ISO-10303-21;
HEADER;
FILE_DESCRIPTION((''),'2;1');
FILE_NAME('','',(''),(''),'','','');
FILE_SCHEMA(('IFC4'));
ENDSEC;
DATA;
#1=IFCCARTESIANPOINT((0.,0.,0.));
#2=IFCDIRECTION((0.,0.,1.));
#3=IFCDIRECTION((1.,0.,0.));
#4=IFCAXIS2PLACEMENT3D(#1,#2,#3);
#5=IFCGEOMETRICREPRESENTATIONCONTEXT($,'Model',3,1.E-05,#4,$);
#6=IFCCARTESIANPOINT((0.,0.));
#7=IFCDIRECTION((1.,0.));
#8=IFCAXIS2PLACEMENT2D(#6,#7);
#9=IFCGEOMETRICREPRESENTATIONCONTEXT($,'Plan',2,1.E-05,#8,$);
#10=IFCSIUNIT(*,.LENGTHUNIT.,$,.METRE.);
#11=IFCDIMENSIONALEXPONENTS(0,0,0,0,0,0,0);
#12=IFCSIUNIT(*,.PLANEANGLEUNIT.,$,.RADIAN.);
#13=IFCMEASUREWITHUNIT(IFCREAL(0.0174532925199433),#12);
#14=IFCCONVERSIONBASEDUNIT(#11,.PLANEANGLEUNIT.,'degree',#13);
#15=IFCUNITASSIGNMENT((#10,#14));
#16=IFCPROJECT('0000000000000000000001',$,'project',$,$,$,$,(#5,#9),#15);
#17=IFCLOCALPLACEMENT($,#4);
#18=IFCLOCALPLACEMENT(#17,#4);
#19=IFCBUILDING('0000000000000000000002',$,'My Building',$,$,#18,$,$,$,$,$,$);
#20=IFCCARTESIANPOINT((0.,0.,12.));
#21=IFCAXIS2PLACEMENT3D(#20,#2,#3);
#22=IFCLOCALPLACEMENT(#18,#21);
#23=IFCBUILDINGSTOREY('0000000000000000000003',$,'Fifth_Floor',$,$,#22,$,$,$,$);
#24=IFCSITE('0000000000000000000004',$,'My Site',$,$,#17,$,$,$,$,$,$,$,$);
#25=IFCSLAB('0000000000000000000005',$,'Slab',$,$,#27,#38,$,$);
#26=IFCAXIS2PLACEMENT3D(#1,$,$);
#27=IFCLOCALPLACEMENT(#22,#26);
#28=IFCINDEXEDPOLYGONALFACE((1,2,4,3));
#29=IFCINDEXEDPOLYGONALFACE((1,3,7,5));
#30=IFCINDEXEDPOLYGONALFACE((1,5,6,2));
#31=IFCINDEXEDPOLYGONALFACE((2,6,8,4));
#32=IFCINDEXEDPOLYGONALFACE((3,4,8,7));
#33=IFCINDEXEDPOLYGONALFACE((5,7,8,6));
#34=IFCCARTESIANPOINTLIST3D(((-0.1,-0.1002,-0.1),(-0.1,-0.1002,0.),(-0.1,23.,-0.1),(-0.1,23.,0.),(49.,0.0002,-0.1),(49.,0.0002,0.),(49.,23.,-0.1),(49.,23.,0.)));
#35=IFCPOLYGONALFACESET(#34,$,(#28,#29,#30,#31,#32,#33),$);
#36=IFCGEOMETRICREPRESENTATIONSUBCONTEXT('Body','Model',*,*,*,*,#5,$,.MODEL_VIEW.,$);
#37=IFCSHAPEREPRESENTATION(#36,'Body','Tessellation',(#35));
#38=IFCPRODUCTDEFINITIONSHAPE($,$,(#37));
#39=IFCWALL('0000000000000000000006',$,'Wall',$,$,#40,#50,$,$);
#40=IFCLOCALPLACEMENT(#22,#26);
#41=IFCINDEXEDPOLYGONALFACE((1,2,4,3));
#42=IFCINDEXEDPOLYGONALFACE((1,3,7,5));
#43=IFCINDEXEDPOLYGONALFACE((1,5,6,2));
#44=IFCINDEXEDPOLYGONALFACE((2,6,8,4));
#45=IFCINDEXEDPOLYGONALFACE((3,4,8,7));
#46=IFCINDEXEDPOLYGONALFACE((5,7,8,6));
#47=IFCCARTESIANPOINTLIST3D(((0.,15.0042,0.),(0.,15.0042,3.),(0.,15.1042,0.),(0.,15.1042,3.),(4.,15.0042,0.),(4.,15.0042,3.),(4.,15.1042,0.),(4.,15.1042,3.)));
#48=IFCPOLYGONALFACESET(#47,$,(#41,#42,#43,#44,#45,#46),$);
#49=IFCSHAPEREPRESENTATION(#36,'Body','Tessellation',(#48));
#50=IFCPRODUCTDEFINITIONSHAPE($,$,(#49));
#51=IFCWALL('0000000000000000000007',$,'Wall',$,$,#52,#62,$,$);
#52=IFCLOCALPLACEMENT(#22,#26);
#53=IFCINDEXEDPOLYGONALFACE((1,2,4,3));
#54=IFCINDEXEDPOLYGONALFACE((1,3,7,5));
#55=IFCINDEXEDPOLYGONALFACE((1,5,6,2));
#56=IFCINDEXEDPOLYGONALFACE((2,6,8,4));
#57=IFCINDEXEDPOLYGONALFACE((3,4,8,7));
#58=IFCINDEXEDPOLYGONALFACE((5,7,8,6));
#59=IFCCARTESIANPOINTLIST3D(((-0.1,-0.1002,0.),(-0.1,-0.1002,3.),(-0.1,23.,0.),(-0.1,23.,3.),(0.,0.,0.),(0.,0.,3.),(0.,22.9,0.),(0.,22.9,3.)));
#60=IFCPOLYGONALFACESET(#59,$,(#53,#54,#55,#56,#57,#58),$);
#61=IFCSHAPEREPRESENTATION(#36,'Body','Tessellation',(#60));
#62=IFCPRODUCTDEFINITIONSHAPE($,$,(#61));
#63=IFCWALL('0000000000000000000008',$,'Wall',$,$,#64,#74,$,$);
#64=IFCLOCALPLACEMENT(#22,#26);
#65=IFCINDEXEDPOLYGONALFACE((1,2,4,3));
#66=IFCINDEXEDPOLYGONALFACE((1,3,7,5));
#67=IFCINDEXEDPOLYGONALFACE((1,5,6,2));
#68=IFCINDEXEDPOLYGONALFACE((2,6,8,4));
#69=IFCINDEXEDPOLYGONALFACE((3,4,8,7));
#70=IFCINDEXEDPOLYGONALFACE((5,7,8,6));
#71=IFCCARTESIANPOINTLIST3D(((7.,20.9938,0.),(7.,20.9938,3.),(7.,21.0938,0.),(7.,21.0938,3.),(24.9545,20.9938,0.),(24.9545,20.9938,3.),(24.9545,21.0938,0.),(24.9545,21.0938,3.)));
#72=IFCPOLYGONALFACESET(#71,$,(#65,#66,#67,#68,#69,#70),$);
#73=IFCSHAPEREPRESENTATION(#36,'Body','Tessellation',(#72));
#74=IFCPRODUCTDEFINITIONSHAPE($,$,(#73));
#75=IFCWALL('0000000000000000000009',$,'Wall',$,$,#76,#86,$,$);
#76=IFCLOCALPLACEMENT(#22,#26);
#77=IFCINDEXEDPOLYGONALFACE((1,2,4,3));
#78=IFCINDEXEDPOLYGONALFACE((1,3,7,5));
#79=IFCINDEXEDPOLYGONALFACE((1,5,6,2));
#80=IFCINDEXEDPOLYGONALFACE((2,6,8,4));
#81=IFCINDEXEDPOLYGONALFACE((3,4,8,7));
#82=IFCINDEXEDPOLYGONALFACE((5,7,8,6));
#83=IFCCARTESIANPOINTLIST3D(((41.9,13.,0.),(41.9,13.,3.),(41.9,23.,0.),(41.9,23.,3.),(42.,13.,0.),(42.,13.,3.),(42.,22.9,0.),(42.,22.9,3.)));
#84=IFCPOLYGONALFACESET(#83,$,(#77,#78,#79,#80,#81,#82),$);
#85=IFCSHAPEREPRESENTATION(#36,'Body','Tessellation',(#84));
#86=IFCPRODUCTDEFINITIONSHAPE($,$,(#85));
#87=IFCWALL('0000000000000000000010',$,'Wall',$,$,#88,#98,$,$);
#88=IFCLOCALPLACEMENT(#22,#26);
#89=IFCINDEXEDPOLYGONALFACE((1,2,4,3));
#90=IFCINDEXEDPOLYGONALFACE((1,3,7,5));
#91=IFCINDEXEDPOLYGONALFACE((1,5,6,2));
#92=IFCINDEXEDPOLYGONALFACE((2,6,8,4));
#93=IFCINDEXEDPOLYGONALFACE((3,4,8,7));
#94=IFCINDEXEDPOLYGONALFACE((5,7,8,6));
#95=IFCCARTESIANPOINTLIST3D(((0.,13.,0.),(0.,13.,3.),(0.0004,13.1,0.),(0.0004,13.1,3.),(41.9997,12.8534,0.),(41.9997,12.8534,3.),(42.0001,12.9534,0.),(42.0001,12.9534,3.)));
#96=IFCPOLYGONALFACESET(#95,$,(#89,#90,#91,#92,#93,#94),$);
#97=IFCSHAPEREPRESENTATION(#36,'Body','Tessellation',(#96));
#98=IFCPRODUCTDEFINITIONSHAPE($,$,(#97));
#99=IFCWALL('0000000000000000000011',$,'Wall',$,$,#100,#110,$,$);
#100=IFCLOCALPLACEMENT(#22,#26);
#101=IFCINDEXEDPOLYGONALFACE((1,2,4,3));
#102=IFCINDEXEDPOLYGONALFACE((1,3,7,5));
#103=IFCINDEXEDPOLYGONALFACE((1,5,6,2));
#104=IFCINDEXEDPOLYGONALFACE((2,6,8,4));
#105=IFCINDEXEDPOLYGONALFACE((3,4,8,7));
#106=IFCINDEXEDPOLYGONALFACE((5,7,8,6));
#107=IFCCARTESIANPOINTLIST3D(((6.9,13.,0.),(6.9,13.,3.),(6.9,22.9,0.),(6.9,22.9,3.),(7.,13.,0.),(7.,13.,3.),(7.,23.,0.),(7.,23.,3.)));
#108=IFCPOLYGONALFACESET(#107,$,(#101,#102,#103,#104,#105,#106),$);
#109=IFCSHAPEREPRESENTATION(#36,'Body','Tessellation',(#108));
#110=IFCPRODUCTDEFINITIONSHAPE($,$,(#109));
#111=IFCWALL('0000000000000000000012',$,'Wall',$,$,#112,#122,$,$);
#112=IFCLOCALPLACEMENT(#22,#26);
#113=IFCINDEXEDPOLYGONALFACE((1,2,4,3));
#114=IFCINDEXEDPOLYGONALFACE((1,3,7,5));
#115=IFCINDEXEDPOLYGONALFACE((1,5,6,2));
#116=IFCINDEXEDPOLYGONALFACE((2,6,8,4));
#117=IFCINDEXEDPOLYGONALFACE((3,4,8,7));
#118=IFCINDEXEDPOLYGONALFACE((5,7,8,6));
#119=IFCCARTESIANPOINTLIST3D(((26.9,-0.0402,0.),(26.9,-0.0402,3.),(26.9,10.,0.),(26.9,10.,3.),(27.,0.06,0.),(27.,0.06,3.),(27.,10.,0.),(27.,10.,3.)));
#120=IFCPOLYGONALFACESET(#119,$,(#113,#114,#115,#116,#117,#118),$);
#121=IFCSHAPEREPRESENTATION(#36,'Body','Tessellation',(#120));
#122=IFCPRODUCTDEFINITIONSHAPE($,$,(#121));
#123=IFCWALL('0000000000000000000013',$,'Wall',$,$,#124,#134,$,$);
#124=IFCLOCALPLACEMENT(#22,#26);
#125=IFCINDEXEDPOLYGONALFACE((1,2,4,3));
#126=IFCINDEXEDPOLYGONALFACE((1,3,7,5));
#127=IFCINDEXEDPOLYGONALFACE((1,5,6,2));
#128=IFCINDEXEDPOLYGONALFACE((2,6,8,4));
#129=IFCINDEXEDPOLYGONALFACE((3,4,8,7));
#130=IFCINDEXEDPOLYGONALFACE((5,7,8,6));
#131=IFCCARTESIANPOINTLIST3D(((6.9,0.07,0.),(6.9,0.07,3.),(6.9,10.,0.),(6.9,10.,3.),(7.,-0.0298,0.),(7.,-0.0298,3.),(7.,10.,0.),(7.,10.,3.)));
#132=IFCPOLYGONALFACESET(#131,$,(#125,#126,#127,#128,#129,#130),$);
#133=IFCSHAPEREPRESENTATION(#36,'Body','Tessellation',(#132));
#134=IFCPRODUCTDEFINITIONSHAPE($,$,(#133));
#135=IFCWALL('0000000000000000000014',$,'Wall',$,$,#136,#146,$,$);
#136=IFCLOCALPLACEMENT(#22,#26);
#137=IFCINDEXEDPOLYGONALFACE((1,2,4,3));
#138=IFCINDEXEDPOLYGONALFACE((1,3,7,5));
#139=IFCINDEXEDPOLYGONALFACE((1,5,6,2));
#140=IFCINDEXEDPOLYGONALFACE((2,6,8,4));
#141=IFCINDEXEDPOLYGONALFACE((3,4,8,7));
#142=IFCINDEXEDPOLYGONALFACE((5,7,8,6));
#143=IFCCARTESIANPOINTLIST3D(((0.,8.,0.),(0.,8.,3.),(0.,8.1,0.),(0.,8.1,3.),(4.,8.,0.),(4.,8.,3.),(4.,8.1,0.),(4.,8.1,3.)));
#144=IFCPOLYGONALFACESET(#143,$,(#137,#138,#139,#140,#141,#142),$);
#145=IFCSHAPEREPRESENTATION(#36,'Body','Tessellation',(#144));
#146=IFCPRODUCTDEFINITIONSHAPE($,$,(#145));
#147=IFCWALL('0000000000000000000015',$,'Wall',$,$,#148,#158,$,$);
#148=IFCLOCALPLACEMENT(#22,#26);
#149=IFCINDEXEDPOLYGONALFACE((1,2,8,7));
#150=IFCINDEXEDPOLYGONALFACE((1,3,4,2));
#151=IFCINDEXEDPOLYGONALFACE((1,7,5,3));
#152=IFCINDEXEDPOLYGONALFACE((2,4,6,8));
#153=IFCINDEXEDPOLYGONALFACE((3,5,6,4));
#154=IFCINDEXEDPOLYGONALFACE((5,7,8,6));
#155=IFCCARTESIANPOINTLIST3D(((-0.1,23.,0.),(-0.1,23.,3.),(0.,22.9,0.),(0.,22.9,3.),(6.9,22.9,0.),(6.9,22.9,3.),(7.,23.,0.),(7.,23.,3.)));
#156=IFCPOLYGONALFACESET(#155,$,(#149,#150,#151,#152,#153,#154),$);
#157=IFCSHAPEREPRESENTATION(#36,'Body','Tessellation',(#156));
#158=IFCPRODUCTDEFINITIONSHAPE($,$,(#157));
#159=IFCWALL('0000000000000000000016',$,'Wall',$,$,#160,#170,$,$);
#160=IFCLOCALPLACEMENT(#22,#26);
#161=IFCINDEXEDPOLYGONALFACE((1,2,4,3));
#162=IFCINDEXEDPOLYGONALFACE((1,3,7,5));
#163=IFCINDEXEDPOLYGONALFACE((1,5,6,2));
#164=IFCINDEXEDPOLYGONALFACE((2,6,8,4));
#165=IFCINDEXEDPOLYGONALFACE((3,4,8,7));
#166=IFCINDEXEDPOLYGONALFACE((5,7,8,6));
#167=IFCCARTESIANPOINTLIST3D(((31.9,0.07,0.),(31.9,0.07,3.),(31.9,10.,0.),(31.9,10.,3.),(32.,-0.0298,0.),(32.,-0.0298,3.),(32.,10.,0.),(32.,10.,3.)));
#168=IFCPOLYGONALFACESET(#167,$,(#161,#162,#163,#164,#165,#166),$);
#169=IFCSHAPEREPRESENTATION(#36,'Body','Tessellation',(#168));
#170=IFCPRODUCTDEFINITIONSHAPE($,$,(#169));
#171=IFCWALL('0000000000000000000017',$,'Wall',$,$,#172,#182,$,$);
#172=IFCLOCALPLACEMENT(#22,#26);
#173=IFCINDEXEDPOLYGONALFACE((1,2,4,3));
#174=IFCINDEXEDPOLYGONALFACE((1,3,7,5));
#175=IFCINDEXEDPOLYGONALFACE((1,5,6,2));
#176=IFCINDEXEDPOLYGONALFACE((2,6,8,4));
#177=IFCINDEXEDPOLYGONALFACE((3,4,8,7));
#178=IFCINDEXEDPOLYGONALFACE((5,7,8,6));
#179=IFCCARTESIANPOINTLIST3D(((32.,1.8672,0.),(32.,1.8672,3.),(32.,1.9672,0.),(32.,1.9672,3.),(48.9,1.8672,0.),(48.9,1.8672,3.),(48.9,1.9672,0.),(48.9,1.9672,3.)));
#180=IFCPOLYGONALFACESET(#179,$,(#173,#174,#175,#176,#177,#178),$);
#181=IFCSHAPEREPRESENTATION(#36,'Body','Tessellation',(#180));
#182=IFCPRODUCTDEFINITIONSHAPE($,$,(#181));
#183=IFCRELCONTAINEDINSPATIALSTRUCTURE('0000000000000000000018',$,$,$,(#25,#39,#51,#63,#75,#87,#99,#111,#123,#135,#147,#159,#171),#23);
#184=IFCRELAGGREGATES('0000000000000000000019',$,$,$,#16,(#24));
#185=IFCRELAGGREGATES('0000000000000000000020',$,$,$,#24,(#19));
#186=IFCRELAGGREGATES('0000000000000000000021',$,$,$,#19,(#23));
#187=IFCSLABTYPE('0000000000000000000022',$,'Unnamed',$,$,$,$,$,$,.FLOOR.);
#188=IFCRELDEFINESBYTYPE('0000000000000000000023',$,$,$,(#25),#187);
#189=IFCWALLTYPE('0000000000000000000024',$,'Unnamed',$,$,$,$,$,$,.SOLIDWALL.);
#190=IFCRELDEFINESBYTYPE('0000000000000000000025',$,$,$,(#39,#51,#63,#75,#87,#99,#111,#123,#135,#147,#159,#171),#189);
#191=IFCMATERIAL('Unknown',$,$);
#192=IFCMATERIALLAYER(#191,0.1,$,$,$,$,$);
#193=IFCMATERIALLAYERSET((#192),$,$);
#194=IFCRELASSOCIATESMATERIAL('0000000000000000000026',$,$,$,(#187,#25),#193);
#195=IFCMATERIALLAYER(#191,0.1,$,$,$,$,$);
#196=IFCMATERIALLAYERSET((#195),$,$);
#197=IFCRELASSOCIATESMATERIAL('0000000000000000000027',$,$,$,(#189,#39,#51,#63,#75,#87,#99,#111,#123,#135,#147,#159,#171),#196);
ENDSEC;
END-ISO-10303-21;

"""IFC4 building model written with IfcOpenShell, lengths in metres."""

from ifc_helpers import new_model, entity, si_unit, converted_unit, frame, origin_with_axes, origin_2d_with_axis, place, context, subcontext, project, spatial, line, indexed_curve, outline, extrude, material, layer, layer_set, layer_usage, type_object, element, save


model = new_model("IFC4")

# Units and contexts
model_context = context("Model", 3, precision=1e-05, world=origin_with_axes())
plan_context = context("Plan", 2, precision=1e-05, world=origin_2d_with_axis())
body_context = subcontext(model_context, "Body", "Model", "MODEL_VIEW")
ifc_project = project(units=[si_unit("LENGTHUNIT", "METRE"), converted_unit("PLANEANGLEUNIT", "degree", entity("IfcReal", 0.0174532925199433), si_unit("PLANEANGLEUNIT", "RADIAN"), dimensions=[0, 0, 0, 0, 0, 0, 0])], contexts=[model_context, plan_context])

# Site, building, storey
site_placement = place(None, origin_with_axes())
site = spatial("IfcSite", under=ifc_project, at=site_placement, Name="My Site")
building_placement = place(site_placement, origin_with_axes())
building = spatial("IfcBuilding", under=site, at=building_placement, Name="My Building")
storey_placement = place(building_placement, frame((0.0, 0.0, 12.0), z_axis=(0.0, 0.0, 1.0), x_axis=(1.0, 0.0, 0.0)))
storey = spatial("IfcBuildingStorey", under=building, at=storey_placement, Name="Fifth_Floor")

# Slab
ifc_material = material(Name="Unknown")
ifc_layer_1 = layer(ifc_material, 0.1)
ifc_layer_set_1 = layer_set([ifc_layer_1])
ifc_layer_usage_1 = layer_usage(ifc_layer_set_1, "AXIS3", "POSITIVE", -0.1)
slab_type = type_object("IfcSlabType", Name="Unnamed", PredefinedType="FLOOR", material=ifc_layer_set_1)
slab_placement = place(storey_placement, frame((-0.1, 23.0, 0.0), z_axis=(0.0, 0.0, 1.0), x_axis=(1.0, 0.0, 0.0)))
element("IfcSlab", 1, at=slab_placement, inside=storey, type_object=slab_type, material=ifc_layer_usage_1, Name="Slab", context=body_context, shape_type="SweptSolid", body=[
    extrude(outline(indexed_curve([(0.0, -23.1002), (49.1, -22.9998), (49.1, 0.0), (0.0, 0.0), (0.0, -23.1002)])), frame((0.0, 0.0, -0.1), z_axis=(0.0, 0.0, 1.0), x_axis=(1.0, 0.0, 0.0)), (0.0, 0.0, 1.0), 0.1),
])

# Walls
ifc_layer_2 = layer(ifc_material, 0.1)
ifc_layer_set_2 = layer_set([ifc_layer_2])
ifc_layer_usage_2 = layer_usage(ifc_layer_set_2, "AXIS2", "POSITIVE", 0.0)
wall_type = type_object("IfcWallType", Name="Unnamed", PredefinedType="SOLIDWALL", material=ifc_layer_set_2)
wall_1_placement = place(storey_placement, frame((0.0, 15.0042, 0.0), z_axis=(0.0, 0.0, 1.0), x_axis=(1.0, 0.0, 0.0)))
element("IfcWall", 2, at=wall_1_placement, inside=storey, type_object=wall_type, material=ifc_layer_usage_2, Name="Wall", context=body_context, shape_type="SweptSolid", body=[
    extrude(outline(indexed_curve([(0.0, 0.0), (0.0, 0.1), (4.0, 0.1), (4.0, 0.0)], segments=[line(1, 2, 3, 4, 1)])), origin_with_axes(), (0.0, 0.0, 1.0), 3.0),
])
ifc_layer_usage_3 = layer_usage(ifc_layer_set_2, "AXIS2", "POSITIVE", 0.0)
wall_2_placement = place(storey_placement, frame((0.0, 0.0, 0.0), z_axis=(0.0, 0.0, 1.0), x_axis=(0.0, 1.0, 0.0)))
element("IfcWall", 3, at=wall_2_placement, inside=storey, type_object=wall_type, material=ifc_layer_usage_3, Name="Wall", context=body_context, shape_type="SweptSolid", body=[
    extrude(outline(indexed_curve([(0.0, 0.0), (-0.1002, 0.1), (23.0, 0.1), (22.9, 0.0)], segments=[line(1, 2, 3, 4, 1)])), origin_with_axes(), (0.0, 0.0, 1.0), 3.0),
])
ifc_layer_usage_4 = layer_usage(ifc_layer_set_2, "AXIS2", "POSITIVE", 0.0)
wall_3_placement = place(storey_placement, frame((7.0, 20.9938, 0.0), z_axis=(0.0, 0.0, 1.0), x_axis=(1.0, 0.0, 0.0)))
element("IfcWall", 4, at=wall_3_placement, inside=storey, type_object=wall_type, material=ifc_layer_usage_4, Name="Wall", context=body_context, shape_type="SweptSolid", body=[
    extrude(outline(indexed_curve([(0.0, 0.0), (0.0, 0.1), (17.9545, 0.1), (17.9545, 0.0)], segments=[line(1, 2, 3, 4, 1)])), origin_with_axes(), (0.0, 0.0, 1.0), 3.0),
])
ifc_layer_usage_5 = layer_usage(ifc_layer_set_2, "AXIS2", "POSITIVE", 0.0)
wall_4_placement = place(storey_placement, frame((41.9, 22.9, 0.0), z_axis=(0.0, 0.0, 1.0), x_axis=(0.0, -1.0, 0.0)))
element("IfcWall", 5, at=wall_4_placement, inside=storey, type_object=wall_type, material=ifc_layer_usage_5, Name="Wall", context=body_context, shape_type="SweptSolid", body=[
    extrude(outline(indexed_curve([(-0.1, 0.0), (0.0, 0.1), (9.9, 0.1), (9.9, 0.0)], segments=[line(1, 2, 3, 4, 1)])), origin_with_axes(), (0.0, 0.0, 1.0), 3.0),
])
ifc_layer_usage_6 = layer_usage(ifc_layer_set_2, "AXIS2", "POSITIVE", 0.0)
wall_5_placement = place(storey_placement, frame((0.0, 13.0, 0.0), z_axis=(0.0, 0.0, 1.0), x_axis=(0.999994, -0.003491, 0.0)))
element("IfcWall", 6, at=wall_5_placement, inside=storey, type_object=wall_type, material=ifc_layer_usage_6, Name="Wall", context=body_context, shape_type="SweptSolid", body=[
    extrude(outline(indexed_curve([(0.0, 0.0), (0.0, 0.1), (42.0, 0.1), (42.0, 0.0)], segments=[line(1, 2, 3, 4, 1)])), origin_with_axes(), (0.0, 0.0, 1.0), 3.0),
])
ifc_layer_usage_7 = layer_usage(ifc_layer_set_2, "AXIS2", "POSITIVE", 0.0)
wall_6_placement = place(storey_placement, frame((6.9, 22.9, 0.0), z_axis=(0.0, 0.0, 1.0), x_axis=(0.0, -1.0, 0.0)))
element("IfcWall", 7, at=wall_6_placement, inside=storey, type_object=wall_type, material=ifc_layer_usage_7, Name="Wall", context=body_context, shape_type="SweptSolid", body=[
    extrude(outline(indexed_curve([(0.0, 0.0), (-0.1, 0.1), (9.9, 0.1), (9.9, 0.0)], segments=[line(1, 2, 3, 4, 1)])), origin_with_axes(), (0.0, 0.0, 1.0), 3.0),
])
ifc_layer_usage_8 = layer_usage(ifc_layer_set_2, "AXIS2", "POSITIVE", 0.0)
wall_7_placement = place(storey_placement, frame((26.9, 10.0, 0.0), z_axis=(0.0, 0.0, 1.0), x_axis=(0.0, -1.0, 0.0)))
element("IfcWall", 8, at=wall_7_placement, inside=storey, type_object=wall_type, material=ifc_layer_usage_8, Name="Wall", context=body_context, shape_type="SweptSolid", body=[
    extrude(outline(indexed_curve([(0.0, 0.0), (0.0, 0.1), (9.94, 0.1), (10.0402, 0.0)], segments=[line(1, 2, 3, 4, 1)])), origin_with_axes(), (0.0, 0.0, 1.0), 3.0),
])
ifc_layer_usage_9 = layer_usage(ifc_layer_set_2, "AXIS2", "POSITIVE", 0.0)
wall_8_placement = place(storey_placement, frame((6.9, 10.0, 0.0), z_axis=(0.0, 0.0, 1.0), x_axis=(0.0, -1.0, 0.0)))
element("IfcWall", 9, at=wall_8_placement, inside=storey, type_object=wall_type, material=ifc_layer_usage_9, Name="Wall", context=body_context, shape_type="SweptSolid", body=[
    extrude(outline(indexed_curve([(0.0, 0.0), (0.0, 0.1), (10.0298, 0.1), (9.93, 0.0)], segments=[line(1, 2, 3, 4, 1)])), origin_with_axes(), (0.0, 0.0, 1.0), 3.0),
])
ifc_layer_usage_10 = layer_usage(ifc_layer_set_2, "AXIS2", "POSITIVE", 0.0)
wall_9_placement = place(storey_placement, frame((0.0, 8.0, 0.0), z_axis=(0.0, 0.0, 1.0), x_axis=(1.0, 0.0, 0.0)))
element("IfcWall", 10, at=wall_9_placement, inside=storey, type_object=wall_type, material=ifc_layer_usage_10, Name="Wall", context=body_context, shape_type="SweptSolid", body=[
    extrude(outline(indexed_curve([(0.0, 0.0), (0.0, 0.1), (4.0, 0.1), (4.0, 0.0)], segments=[line(1, 2, 3, 4, 1)])), origin_with_axes(), (0.0, 0.0, 1.0), 3.0),
])
ifc_layer_usage_11 = layer_usage(ifc_layer_set_2, "AXIS2", "POSITIVE", 0.0)
wall_10_placement = place(storey_placement, frame((0.0, 22.9, 0.0), z_axis=(0.0, 0.0, 1.0), x_axis=(1.0, 0.0, 0.0)))
element("IfcWall", 11, at=wall_10_placement, inside=storey, type_object=wall_type, material=ifc_layer_usage_11, Name="Wall", context=body_context, shape_type="SweptSolid", body=[
    extrude(outline(indexed_curve([(0.0, 0.0), (-0.1, 0.1), (7.0, 0.1), (6.9, 0.0)], segments=[line(1, 2, 3, 4, 1)])), origin_with_axes(), (0.0, 0.0, 1.0), 3.0),
])
ifc_layer_usage_12 = layer_usage(ifc_layer_set_2, "AXIS2", "POSITIVE", 0.0)
wall_11_placement = place(storey_placement, frame((31.9, 10.0, 0.0), z_axis=(0.0, 0.0, 1.0), x_axis=(0.0, -1.0, 0.0)))
element("IfcWall", 12, at=wall_11_placement, inside=storey, type_object=wall_type, material=ifc_layer_usage_12, Name="Wall", context=body_context, shape_type="SweptSolid", body=[
    extrude(outline(indexed_curve([(0.0, 0.0), (0.0, 0.1), (10.0298, 0.1), (9.93, 0.0)], segments=[line(1, 2, 3, 4, 1)])), origin_with_axes(), (0.0, 0.0, 1.0), 3.0),
])
ifc_layer_usage_13 = layer_usage(ifc_layer_set_2, "AXIS2", "POSITIVE", 0.0)
wall_12_placement = place(storey_placement, frame((32.0, 1.8672, 0.0), z_axis=(0.0, 0.0, 1.0), x_axis=(1.0, 0.0, 0.0)))
element("IfcWall", 13, at=wall_12_placement, inside=storey, type_object=wall_type, material=ifc_layer_usage_13, Name="Wall", context=body_context, shape_type="SweptSolid", body=[
    extrude(outline(indexed_curve([(0.0, 0.0), (0.0, 0.1), (16.9, 0.1), (16.9, 0.0)], segments=[line(1, 2, 3, 4, 1)])), origin_with_axes(), (0.0, 0.0, 1.0), 3.0),
])

save(model, "model.ifc")
